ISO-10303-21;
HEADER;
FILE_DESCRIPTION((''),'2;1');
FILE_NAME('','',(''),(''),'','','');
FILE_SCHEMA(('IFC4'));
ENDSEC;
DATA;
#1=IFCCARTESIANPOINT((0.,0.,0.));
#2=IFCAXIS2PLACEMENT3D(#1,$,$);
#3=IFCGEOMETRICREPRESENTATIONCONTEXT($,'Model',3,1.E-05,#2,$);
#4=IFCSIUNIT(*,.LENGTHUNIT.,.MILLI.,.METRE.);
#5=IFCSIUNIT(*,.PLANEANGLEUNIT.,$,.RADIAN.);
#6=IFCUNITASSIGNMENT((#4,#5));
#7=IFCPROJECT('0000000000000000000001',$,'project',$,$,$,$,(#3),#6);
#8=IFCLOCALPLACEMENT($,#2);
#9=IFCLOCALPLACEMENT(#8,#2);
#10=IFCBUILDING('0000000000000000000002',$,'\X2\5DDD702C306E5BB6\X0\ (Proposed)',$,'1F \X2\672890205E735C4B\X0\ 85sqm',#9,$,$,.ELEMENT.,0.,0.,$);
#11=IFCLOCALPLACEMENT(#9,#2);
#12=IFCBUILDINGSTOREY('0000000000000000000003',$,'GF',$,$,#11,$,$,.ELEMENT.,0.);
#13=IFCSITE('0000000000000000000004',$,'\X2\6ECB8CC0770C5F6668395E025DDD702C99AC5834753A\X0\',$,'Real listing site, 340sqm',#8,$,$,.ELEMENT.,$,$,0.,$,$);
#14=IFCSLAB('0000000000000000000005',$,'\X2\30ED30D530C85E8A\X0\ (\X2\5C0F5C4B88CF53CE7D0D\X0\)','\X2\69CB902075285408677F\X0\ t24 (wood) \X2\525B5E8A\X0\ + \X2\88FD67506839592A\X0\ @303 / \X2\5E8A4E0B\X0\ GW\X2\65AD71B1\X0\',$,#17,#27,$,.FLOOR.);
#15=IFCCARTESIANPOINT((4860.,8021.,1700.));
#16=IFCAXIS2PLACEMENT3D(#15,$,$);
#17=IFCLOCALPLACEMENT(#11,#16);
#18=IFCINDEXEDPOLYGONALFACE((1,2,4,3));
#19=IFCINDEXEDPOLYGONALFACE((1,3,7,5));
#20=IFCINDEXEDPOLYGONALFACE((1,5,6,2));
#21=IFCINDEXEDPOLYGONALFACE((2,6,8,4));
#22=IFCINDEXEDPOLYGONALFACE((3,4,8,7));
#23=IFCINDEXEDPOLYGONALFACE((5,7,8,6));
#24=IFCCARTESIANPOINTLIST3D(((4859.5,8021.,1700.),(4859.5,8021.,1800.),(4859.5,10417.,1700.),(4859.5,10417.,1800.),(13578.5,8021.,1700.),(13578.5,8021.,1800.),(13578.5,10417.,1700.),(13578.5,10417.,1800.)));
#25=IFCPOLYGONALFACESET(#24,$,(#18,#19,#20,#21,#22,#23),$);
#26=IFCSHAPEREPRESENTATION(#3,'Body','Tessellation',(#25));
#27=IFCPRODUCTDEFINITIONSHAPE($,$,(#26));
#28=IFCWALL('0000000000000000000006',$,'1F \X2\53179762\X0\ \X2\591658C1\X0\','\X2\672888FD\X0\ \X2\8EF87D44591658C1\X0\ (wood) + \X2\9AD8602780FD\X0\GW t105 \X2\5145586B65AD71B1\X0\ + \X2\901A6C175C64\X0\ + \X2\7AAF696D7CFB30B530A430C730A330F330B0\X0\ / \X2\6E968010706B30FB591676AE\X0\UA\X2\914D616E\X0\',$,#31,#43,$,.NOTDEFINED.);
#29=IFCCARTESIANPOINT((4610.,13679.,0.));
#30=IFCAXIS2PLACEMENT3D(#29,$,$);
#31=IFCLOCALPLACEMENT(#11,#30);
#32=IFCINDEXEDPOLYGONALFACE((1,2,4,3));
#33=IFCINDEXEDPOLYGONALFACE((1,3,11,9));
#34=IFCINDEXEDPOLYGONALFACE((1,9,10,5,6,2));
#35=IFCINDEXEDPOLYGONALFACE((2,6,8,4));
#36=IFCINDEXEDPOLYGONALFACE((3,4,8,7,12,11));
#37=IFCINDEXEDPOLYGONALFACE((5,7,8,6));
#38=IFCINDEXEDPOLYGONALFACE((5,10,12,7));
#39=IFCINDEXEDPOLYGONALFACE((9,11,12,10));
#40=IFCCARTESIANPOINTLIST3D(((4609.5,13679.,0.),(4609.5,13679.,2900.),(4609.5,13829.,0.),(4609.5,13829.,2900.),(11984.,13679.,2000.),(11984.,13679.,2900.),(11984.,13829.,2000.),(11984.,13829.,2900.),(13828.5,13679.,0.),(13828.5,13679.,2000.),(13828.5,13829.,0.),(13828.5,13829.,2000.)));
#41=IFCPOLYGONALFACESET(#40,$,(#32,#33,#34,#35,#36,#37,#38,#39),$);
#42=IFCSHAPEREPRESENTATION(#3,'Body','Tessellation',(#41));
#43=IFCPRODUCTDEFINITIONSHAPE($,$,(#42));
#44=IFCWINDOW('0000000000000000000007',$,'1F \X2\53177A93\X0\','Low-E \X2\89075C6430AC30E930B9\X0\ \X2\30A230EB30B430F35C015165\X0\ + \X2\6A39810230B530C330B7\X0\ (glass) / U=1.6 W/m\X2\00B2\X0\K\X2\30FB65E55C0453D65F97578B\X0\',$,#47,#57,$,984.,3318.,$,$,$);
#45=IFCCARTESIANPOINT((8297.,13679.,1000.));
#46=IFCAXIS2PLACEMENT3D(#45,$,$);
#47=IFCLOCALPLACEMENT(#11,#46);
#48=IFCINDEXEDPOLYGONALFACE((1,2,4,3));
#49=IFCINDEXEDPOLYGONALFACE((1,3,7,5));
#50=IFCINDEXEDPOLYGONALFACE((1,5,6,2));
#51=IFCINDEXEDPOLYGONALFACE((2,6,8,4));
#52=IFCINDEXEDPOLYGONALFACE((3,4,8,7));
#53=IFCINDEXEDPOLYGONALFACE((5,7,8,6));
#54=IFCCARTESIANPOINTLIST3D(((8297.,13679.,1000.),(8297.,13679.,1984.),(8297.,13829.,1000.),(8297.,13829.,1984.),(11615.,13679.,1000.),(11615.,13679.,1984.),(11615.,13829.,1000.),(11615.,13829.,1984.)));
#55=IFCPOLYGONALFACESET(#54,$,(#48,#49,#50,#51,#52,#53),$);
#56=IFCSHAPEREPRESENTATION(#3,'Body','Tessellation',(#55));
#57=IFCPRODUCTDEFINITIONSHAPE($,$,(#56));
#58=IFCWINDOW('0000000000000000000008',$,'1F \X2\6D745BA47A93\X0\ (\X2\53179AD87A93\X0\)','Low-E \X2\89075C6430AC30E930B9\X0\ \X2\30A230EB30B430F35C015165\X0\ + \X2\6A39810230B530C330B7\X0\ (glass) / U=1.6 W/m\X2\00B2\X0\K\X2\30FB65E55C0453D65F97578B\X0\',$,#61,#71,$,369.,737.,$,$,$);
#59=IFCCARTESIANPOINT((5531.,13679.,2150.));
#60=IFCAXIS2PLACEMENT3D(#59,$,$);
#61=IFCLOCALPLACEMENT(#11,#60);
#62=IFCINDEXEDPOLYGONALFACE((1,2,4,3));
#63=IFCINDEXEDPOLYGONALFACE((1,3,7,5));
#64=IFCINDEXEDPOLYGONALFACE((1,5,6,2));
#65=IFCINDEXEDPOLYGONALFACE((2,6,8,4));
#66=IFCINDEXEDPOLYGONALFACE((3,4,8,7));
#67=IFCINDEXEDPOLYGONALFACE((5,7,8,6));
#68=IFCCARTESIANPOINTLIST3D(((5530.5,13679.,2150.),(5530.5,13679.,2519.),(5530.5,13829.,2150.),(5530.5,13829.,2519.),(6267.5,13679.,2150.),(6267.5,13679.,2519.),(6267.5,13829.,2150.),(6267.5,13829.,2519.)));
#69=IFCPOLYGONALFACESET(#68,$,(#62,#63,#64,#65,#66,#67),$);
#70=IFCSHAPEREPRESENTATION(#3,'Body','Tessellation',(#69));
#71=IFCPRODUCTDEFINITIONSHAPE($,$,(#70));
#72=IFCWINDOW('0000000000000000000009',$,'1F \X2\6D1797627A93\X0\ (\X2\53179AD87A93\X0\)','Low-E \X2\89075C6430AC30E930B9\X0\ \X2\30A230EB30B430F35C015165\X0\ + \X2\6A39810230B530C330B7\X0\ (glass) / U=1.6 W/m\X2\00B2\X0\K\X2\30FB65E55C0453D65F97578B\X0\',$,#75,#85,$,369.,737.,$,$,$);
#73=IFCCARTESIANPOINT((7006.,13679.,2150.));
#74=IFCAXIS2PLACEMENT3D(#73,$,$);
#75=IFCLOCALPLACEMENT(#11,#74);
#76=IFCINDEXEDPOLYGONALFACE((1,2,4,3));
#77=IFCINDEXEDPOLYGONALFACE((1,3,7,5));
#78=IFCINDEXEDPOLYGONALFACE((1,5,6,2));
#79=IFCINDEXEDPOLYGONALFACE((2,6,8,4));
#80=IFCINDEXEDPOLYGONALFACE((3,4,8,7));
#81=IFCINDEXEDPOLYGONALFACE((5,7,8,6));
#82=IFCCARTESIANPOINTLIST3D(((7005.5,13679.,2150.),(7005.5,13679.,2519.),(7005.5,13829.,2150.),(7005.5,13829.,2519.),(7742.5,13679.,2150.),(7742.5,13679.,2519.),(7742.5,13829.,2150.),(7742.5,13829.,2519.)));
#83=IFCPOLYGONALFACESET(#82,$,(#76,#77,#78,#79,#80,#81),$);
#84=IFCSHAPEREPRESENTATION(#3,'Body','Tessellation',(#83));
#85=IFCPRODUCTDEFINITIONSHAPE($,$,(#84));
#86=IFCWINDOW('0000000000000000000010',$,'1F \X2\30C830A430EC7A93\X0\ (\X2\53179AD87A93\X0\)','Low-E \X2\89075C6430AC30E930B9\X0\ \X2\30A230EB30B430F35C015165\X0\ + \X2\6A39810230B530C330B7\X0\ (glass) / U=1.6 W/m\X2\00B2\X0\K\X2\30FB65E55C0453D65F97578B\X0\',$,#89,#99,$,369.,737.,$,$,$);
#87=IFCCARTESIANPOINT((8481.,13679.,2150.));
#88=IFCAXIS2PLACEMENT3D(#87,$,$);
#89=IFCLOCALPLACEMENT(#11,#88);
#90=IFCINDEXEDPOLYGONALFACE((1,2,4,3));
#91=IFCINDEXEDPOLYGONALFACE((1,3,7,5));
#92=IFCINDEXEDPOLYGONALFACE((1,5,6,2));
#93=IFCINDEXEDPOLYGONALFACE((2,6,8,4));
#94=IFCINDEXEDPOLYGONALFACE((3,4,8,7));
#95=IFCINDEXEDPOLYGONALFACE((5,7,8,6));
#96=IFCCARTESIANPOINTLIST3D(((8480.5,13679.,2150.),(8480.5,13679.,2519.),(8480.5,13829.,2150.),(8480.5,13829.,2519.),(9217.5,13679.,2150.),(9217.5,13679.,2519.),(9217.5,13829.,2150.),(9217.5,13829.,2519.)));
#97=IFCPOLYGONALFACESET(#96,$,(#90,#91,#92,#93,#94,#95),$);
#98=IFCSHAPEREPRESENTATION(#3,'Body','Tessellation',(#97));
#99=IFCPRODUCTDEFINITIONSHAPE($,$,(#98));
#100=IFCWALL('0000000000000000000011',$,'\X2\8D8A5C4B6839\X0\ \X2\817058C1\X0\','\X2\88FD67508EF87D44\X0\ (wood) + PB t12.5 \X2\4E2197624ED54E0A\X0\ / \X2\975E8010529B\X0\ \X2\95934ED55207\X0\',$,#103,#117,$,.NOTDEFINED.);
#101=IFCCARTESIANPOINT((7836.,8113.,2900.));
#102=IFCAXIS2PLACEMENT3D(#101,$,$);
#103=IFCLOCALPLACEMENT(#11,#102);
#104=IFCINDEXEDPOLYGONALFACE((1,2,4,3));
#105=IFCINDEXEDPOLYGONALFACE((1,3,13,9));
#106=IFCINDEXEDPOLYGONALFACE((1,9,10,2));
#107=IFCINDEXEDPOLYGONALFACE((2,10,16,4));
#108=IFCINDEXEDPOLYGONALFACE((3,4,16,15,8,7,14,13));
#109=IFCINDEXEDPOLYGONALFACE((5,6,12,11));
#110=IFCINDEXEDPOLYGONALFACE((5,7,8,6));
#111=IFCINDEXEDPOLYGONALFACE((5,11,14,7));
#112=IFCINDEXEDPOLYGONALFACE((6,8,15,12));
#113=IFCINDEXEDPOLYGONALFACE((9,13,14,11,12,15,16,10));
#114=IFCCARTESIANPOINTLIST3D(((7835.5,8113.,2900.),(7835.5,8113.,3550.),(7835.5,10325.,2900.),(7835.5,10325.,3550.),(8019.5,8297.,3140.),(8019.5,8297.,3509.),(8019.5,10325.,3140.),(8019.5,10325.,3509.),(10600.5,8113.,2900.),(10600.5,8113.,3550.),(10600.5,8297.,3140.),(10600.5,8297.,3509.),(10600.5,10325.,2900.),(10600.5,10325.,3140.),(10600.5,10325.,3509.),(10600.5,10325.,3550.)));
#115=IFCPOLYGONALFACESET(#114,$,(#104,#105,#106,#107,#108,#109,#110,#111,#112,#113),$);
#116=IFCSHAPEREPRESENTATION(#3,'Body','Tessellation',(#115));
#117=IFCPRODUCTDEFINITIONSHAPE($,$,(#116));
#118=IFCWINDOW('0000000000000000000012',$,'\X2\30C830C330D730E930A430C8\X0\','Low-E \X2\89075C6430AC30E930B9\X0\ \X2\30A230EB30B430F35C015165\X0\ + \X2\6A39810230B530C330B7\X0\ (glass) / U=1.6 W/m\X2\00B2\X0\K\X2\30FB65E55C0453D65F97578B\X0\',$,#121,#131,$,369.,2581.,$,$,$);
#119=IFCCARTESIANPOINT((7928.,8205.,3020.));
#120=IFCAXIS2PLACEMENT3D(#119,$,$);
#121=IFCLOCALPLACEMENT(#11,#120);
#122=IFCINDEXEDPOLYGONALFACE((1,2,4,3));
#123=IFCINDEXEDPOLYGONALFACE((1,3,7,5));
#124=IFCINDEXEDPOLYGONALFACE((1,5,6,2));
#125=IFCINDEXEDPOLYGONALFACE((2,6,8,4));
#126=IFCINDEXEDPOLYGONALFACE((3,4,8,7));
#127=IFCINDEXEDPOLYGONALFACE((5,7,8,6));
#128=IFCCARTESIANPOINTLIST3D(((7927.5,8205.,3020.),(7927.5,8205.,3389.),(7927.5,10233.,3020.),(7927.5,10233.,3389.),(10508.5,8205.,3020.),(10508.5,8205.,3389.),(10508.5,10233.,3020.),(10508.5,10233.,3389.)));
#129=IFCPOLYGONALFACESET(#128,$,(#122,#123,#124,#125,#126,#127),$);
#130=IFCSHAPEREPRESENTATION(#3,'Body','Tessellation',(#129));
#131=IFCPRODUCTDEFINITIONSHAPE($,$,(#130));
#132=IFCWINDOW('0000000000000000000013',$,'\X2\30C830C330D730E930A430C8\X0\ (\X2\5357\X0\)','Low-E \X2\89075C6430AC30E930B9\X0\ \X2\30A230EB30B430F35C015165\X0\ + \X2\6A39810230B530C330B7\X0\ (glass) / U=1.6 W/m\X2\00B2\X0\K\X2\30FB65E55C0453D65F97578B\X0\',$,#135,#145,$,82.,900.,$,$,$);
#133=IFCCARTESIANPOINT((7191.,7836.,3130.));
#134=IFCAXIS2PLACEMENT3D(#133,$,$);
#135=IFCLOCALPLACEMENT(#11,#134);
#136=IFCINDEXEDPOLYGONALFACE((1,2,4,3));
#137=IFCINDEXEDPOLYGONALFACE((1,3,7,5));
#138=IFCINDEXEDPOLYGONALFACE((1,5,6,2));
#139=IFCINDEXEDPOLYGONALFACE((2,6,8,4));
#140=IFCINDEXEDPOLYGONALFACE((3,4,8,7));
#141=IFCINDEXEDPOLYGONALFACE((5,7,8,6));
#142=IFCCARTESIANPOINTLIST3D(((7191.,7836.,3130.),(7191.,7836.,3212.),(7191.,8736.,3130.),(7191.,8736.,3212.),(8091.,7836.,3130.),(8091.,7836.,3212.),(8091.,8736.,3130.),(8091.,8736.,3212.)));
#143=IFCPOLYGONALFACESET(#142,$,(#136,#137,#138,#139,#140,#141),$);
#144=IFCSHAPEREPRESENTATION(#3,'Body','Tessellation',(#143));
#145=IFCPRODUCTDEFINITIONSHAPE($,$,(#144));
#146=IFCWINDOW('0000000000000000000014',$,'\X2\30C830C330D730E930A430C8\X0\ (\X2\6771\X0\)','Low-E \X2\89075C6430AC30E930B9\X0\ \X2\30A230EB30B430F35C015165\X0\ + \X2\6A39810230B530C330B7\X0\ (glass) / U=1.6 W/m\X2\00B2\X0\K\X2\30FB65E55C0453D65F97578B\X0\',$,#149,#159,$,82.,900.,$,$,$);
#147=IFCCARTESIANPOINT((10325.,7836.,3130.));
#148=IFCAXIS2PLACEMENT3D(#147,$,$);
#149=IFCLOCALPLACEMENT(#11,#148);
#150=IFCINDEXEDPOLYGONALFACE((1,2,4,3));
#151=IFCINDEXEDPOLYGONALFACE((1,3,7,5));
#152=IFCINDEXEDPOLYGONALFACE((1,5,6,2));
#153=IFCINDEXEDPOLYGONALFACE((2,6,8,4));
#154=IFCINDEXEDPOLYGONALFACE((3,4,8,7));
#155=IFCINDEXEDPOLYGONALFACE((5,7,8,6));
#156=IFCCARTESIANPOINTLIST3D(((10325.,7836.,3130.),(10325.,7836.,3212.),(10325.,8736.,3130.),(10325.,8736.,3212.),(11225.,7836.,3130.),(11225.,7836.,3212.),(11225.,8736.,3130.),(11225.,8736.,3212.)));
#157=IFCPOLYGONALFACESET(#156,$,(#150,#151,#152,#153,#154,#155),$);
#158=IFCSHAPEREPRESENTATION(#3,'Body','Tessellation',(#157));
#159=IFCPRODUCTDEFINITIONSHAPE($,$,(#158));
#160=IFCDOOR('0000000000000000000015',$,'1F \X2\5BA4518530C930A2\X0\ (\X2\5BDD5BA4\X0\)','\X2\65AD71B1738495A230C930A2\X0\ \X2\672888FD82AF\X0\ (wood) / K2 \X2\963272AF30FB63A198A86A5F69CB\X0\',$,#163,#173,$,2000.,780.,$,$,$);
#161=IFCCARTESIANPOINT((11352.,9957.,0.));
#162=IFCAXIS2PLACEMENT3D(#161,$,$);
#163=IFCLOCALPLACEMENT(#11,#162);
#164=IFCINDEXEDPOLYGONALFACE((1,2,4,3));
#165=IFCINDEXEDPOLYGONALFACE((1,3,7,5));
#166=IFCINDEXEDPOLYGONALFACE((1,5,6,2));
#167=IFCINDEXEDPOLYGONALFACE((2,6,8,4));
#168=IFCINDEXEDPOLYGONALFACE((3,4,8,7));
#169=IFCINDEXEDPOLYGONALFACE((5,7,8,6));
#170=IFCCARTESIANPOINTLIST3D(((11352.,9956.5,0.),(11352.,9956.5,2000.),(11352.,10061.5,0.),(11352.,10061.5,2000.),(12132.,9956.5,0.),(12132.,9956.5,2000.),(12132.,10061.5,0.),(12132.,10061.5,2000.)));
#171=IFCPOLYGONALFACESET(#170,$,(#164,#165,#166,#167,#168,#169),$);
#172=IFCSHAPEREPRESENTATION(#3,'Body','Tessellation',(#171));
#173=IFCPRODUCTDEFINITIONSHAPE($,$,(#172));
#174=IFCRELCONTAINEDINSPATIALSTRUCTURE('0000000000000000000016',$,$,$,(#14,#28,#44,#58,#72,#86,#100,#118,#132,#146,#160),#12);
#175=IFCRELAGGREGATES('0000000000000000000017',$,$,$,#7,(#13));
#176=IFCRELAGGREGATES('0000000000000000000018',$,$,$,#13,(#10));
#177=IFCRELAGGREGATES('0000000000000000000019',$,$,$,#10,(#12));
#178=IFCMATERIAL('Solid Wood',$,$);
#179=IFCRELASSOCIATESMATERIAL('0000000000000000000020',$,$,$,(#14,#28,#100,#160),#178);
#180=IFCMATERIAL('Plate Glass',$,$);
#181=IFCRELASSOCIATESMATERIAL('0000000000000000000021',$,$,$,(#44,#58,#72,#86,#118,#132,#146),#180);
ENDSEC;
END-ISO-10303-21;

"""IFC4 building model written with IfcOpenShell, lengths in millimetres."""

from ifc_helpers import new_model, si_unit, frame, frame_2d, origin, place, context, project, spatial, rectangle, extrude, material, element, fill, save


model = new_model("IFC4")

# Units and contexts
model_context = context("Model", 3, precision=1e-05, world=origin())
ifc_project = project(units=[si_unit("LENGTHUNIT", "METRE", prefix="MILLI"), si_unit("PLANEANGLEUNIT", "RADIAN")], contexts=[model_context])

# Site, building, storey
site_placement = place(None, origin())
site = spatial("IfcSite", under=ifc_project, at=site_placement, Name="滋賀県彦根市川瀬馬場町", ObjectType="Real listing site, 340sqm", CompositionType="ELEMENT", RefElevation=0.0)
building_placement = place(site_placement, origin())
building = spatial("IfcBuilding", under=site, at=building_placement, Name="川瀬の家 (Proposed)", ObjectType="1F 木造平屋 85sqm", CompositionType="ELEMENT", ElevationOfRefHeight=0.0, ElevationOfTerrain=0.0)
storey_placement = place(building_placement, origin())
storey = spatial("IfcBuildingStorey", under=building, at=storey_placement, Name="GF", CompositionType="ELEMENT", Elevation=0.0)

# Slab
ifc_material_1 = material(Name="Solid Wood")
slab_placement = place(storey_placement, frame((4860.0, 8021.0, 1700.0)))
element("IfcSlab", 1, at=slab_placement, inside=storey, material=ifc_material_1, Name="ロフト床 (小屋裏収納)", Description="構造用合板 t24 (wood) 剛床 + 製材根太 @303 / 床下 GW断熱", PredefinedType="FLOOR", context=model_context, shape_type="SweptSolid", body=[
    extrude(rectangle(XDim=8719.0, YDim=2396.0, at=frame_2d((4359.0, 1198.0))), frame((4860.0, 8021.0, 1700.0)), (0.0, 0.0, 1.0), 100.0),
])

# Wall, openings, windows
wall_1_placement = place(storey_placement, frame((4610.0, 13679.0, 0.0)))
wall_1 = element("IfcWall", 2, at=wall_1_placement, inside=storey, material=ifc_material_1, Name="1F 北面 外壁", Description="木製 軸組外壁 (wood) + 高性能GW t105 充填断熱 + 通気層 + 窯業系サイディング / 準耐火・外皮UA配慮", PredefinedType="NOTDEFINED", context=model_context, shape_type="SweptSolid", body=[
    extrude(rectangle(XDim=9219.0, YDim=150.0, at=frame_2d((4609.0, 75.0))), frame((4610.0, 13679.0, 0.0)), (0.0, 0.0, 1.0), 2900.0),
])
opening_1_placement = place(storey_placement, frame((8297.0, 13679.0, 1000.0)))
opening_1 = element("IfcOpeningElement", 3, at=opening_1_placement, cuts=wall_1, PredefinedType="NOTDEFINED", context=model_context, shape_type="SweptSolid", body=[
    extrude(rectangle(XDim=3318.0, YDim=150.0, at=frame_2d((1659.0, 75.0))), frame((8297.0, 13679.0, 1000.0)), (0.0, 0.0, 1.0), 984.0),
])
opening_2_placement = place(storey_placement, frame((5531.0, 13679.0, 2150.0)))
opening_2 = element("IfcOpeningElement", 4, at=opening_2_placement, cuts=wall_1, PredefinedType="NOTDEFINED", context=model_context, shape_type="SweptSolid", body=[
    extrude(rectangle(XDim=737.0, YDim=150.0, at=frame_2d((368.0, 75.0))), frame((5531.0, 13679.0, 2150.0)), (0.0, 0.0, 1.0), 369.0),
])
opening_3_placement = place(storey_placement, frame((7006.0, 13679.0, 2150.0)))
opening_3 = element("IfcOpeningElement", 5, at=opening_3_placement, cuts=wall_1, PredefinedType="NOTDEFINED", context=model_context, shape_type="SweptSolid", body=[
    extrude(rectangle(XDim=737.0, YDim=150.0, at=frame_2d((368.0, 75.0))), frame((7006.0, 13679.0, 2150.0)), (0.0, 0.0, 1.0), 369.0),
])
opening_4_placement = place(storey_placement, frame((8481.0, 13679.0, 2150.0)))
opening_4 = element("IfcOpeningElement", 6, at=opening_4_placement, cuts=wall_1, PredefinedType="NOTDEFINED", context=model_context, shape_type="SweptSolid", body=[
    extrude(rectangle(XDim=737.0, YDim=150.0, at=frame_2d((368.0, 75.0))), frame((8481.0, 13679.0, 2150.0)), (0.0, 0.0, 1.0), 369.0),
])
ifc_material_2 = material(Name="Plate Glass")
window_1_placement = place(storey_placement, frame((8297.0, 13679.0, 1000.0)))
window_1 = element("IfcWindow", 7, at=window_1_placement, inside=storey, material=ifc_material_2, Name="1F 北窓", Description="Low-E 複層ガラス アルゴン封入 + 樹脂サッシ (glass) / U=1.6 W/m²K・日射取得型", OverallHeight=984.0, OverallWidth=3318.0, context=model_context, shape_type="SweptSolid", body=[
    extrude(rectangle(XDim=3318.0, YDim=150.0, at=frame_2d((1659.0, 75.0))), frame((8297.0, 13679.0, 1000.0)), (0.0, 0.0, 1.0), 984.0),
])
fill(opening_1, window_1)
window_2_placement = place(storey_placement, frame((5531.0, 13679.0, 2150.0)))
window_2 = element("IfcWindow", 8, at=window_2_placement, inside=storey, material=ifc_material_2, Name="1F 浴室窓 (北高窓)", Description="Low-E 複層ガラス アルゴン封入 + 樹脂サッシ (glass) / U=1.6 W/m²K・日射取得型", OverallHeight=369.0, OverallWidth=737.0, context=model_context, shape_type="SweptSolid", body=[
    extrude(rectangle(XDim=737.0, YDim=150.0, at=frame_2d((368.0, 75.0))), frame((5531.0, 13679.0, 2150.0)), (0.0, 0.0, 1.0), 369.0),
])
fill(opening_2, window_2)
window_3_placement = place(storey_placement, frame((7006.0, 13679.0, 2150.0)))
window_3 = element("IfcWindow", 9, at=window_3_placement, inside=storey, material=ifc_material_2, Name="1F 洗面窓 (北高窓)", Description="Low-E 複層ガラス アルゴン封入 + 樹脂サッシ (glass) / U=1.6 W/m²K・日射取得型", OverallHeight=369.0, OverallWidth=737.0, context=model_context, shape_type="SweptSolid", body=[
    extrude(rectangle(XDim=737.0, YDim=150.0, at=frame_2d((368.0, 75.0))), frame((7006.0, 13679.0, 2150.0)), (0.0, 0.0, 1.0), 369.0),
])
fill(opening_3, window_3)
window_4_placement = place(storey_placement, frame((8481.0, 13679.0, 2150.0)))
window_4 = element("IfcWindow", 10, at=window_4_placement, inside=storey, material=ifc_material_2, Name="1F トイレ窓 (北高窓)", Description="Low-E 複層ガラス アルゴン封入 + 樹脂サッシ (glass) / U=1.6 W/m²K・日射取得型", OverallHeight=369.0, OverallWidth=737.0, context=model_context, shape_type="SweptSolid", body=[
    extrude(rectangle(XDim=737.0, YDim=150.0, at=frame_2d((368.0, 75.0))), frame((8481.0, 13679.0, 2150.0)), (0.0, 0.0, 1.0), 369.0),
])
fill(opening_4, window_4)

# Wall, openings, windows
wall_2_placement = place(storey_placement, frame((7836.0, 8113.0, 2900.0)))
wall_2 = element("IfcWall", 11, at=wall_2_placement, inside=storey, material=ifc_material_1, Name="越屋根 腰壁", Description="製材軸組 (wood) + PB t12.5 両面仕上 / 非耐力 間仕切", PredefinedType="NOTDEFINED", context=model_context, shape_type="SweptSolid", body=[
    extrude(rectangle(XDim=2765.0, YDim=2212.0, at=frame_2d((1382.0, 1106.0))), frame((7836.0, 8113.0, 2900.0)), (0.0, 0.0, 1.0), 650.0),
])
opening_5_placement = place(storey_placement, frame((7928.0, 8205.0, 3020.0)))
opening_5 = element("IfcOpeningElement", 12, at=opening_5_placement, cuts=wall_2, PredefinedType="NOTDEFINED", context=model_context, shape_type="SweptSolid", body=[
    extrude(rectangle(XDim=2581.0, YDim=2028.0, at=frame_2d((1290.0, 1014.0))), frame((7928.0, 8205.0, 3020.0)), (0.0, 0.0, 1.0), 369.0),
])
opening_6_placement = place(storey_placement, frame((7191.0, 7836.0, 3130.0)))
opening_6 = element("IfcOpeningElement", 13, at=opening_6_placement, cuts=wall_2, PredefinedType="NOTDEFINED", context=model_context, shape_type="SweptSolid", body=[
    extrude(rectangle(XDim=900.0, YDim=900.0, at=frame_2d((450.0, 450.0))), frame((7191.0, 7836.0, 3130.0)), (0.0, 0.0, 1.0), 82.0),
])
opening_7_placement = place(storey_placement, frame((10325.0, 7836.0, 3130.0)))
opening_7 = element("IfcOpeningElement", 14, at=opening_7_placement, cuts=wall_2, PredefinedType="NOTDEFINED", context=model_context, shape_type="SweptSolid", body=[
    extrude(rectangle(XDim=900.0, YDim=900.0, at=frame_2d((450.0, 450.0))), frame((10325.0, 7836.0, 3130.0)), (0.0, 0.0, 1.0), 82.0),
])
window_5_placement = place(storey_placement, frame((7928.0, 8205.0, 3020.0)))
window_5 = element("IfcWindow", 15, at=window_5_placement, inside=storey, material=ifc_material_2, Name="トップライト", Description="Low-E 複層ガラス アルゴン封入 + 樹脂サッシ (glass) / U=1.6 W/m²K・日射取得型", OverallHeight=369.0, OverallWidth=2581.0, context=model_context, shape_type="SweptSolid", body=[
    extrude(rectangle(XDim=2581.0, YDim=2028.0, at=frame_2d((1290.0, 1014.0))), frame((7928.0, 8205.0, 3020.0)), (0.0, 0.0, 1.0), 369.0),
])
fill(opening_5, window_5)
window_6_placement = place(storey_placement, frame((7191.0, 7836.0, 3130.0)))
window_6 = element("IfcWindow", 16, at=window_6_placement, inside=storey, material=ifc_material_2, Name="トップライト (南)", Description="Low-E 複層ガラス アルゴン封入 + 樹脂サッシ (glass) / U=1.6 W/m²K・日射取得型", OverallHeight=82.0, OverallWidth=900.0, context=model_context, shape_type="SweptSolid", body=[
    extrude(rectangle(XDim=900.0, YDim=900.0, at=frame_2d((450.0, 450.0))), frame((7191.0, 7836.0, 3130.0)), (0.0, 0.0, 1.0), 82.0),
])
fill(opening_6, window_6)
window_7_placement = place(storey_placement, frame((10325.0, 7836.0, 3130.0)))
window_7 = element("IfcWindow", 17, at=window_7_placement, inside=storey, material=ifc_material_2, Name="トップライト (東)", Description="Low-E 複層ガラス アルゴン封入 + 樹脂サッシ (glass) / U=1.6 W/m²K・日射取得型", OverallHeight=82.0, OverallWidth=900.0, context=model_context, shape_type="SweptSolid", body=[
    extrude(rectangle(XDim=900.0, YDim=900.0, at=frame_2d((450.0, 450.0))), frame((10325.0, 7836.0, 3130.0)), (0.0, 0.0, 1.0), 82.0),
])
fill(opening_7, window_7)

# Door
door_1_placement = place(storey_placement, frame((11352.0, 9957.0, 0.0)))
element("IfcDoor", 18, at=door_1_placement, inside=storey, material=ifc_material_1, Name="1F 室内ドア (寝室)", Description="断熱玄関ドア 木製芯 (wood) / K2 防犯・採風機構", OverallHeight=2000.0, OverallWidth=780.0, context=model_context, shape_type="SweptSolid", body=[
    extrude(rectangle(XDim=780.0, YDim=105.0, at=frame_2d((390.0, 52.0))), frame((11352.0, 9957.0, 0.0)), (0.0, 0.0, 1.0), 2000.0),
])

save(model, "model.ifc")
